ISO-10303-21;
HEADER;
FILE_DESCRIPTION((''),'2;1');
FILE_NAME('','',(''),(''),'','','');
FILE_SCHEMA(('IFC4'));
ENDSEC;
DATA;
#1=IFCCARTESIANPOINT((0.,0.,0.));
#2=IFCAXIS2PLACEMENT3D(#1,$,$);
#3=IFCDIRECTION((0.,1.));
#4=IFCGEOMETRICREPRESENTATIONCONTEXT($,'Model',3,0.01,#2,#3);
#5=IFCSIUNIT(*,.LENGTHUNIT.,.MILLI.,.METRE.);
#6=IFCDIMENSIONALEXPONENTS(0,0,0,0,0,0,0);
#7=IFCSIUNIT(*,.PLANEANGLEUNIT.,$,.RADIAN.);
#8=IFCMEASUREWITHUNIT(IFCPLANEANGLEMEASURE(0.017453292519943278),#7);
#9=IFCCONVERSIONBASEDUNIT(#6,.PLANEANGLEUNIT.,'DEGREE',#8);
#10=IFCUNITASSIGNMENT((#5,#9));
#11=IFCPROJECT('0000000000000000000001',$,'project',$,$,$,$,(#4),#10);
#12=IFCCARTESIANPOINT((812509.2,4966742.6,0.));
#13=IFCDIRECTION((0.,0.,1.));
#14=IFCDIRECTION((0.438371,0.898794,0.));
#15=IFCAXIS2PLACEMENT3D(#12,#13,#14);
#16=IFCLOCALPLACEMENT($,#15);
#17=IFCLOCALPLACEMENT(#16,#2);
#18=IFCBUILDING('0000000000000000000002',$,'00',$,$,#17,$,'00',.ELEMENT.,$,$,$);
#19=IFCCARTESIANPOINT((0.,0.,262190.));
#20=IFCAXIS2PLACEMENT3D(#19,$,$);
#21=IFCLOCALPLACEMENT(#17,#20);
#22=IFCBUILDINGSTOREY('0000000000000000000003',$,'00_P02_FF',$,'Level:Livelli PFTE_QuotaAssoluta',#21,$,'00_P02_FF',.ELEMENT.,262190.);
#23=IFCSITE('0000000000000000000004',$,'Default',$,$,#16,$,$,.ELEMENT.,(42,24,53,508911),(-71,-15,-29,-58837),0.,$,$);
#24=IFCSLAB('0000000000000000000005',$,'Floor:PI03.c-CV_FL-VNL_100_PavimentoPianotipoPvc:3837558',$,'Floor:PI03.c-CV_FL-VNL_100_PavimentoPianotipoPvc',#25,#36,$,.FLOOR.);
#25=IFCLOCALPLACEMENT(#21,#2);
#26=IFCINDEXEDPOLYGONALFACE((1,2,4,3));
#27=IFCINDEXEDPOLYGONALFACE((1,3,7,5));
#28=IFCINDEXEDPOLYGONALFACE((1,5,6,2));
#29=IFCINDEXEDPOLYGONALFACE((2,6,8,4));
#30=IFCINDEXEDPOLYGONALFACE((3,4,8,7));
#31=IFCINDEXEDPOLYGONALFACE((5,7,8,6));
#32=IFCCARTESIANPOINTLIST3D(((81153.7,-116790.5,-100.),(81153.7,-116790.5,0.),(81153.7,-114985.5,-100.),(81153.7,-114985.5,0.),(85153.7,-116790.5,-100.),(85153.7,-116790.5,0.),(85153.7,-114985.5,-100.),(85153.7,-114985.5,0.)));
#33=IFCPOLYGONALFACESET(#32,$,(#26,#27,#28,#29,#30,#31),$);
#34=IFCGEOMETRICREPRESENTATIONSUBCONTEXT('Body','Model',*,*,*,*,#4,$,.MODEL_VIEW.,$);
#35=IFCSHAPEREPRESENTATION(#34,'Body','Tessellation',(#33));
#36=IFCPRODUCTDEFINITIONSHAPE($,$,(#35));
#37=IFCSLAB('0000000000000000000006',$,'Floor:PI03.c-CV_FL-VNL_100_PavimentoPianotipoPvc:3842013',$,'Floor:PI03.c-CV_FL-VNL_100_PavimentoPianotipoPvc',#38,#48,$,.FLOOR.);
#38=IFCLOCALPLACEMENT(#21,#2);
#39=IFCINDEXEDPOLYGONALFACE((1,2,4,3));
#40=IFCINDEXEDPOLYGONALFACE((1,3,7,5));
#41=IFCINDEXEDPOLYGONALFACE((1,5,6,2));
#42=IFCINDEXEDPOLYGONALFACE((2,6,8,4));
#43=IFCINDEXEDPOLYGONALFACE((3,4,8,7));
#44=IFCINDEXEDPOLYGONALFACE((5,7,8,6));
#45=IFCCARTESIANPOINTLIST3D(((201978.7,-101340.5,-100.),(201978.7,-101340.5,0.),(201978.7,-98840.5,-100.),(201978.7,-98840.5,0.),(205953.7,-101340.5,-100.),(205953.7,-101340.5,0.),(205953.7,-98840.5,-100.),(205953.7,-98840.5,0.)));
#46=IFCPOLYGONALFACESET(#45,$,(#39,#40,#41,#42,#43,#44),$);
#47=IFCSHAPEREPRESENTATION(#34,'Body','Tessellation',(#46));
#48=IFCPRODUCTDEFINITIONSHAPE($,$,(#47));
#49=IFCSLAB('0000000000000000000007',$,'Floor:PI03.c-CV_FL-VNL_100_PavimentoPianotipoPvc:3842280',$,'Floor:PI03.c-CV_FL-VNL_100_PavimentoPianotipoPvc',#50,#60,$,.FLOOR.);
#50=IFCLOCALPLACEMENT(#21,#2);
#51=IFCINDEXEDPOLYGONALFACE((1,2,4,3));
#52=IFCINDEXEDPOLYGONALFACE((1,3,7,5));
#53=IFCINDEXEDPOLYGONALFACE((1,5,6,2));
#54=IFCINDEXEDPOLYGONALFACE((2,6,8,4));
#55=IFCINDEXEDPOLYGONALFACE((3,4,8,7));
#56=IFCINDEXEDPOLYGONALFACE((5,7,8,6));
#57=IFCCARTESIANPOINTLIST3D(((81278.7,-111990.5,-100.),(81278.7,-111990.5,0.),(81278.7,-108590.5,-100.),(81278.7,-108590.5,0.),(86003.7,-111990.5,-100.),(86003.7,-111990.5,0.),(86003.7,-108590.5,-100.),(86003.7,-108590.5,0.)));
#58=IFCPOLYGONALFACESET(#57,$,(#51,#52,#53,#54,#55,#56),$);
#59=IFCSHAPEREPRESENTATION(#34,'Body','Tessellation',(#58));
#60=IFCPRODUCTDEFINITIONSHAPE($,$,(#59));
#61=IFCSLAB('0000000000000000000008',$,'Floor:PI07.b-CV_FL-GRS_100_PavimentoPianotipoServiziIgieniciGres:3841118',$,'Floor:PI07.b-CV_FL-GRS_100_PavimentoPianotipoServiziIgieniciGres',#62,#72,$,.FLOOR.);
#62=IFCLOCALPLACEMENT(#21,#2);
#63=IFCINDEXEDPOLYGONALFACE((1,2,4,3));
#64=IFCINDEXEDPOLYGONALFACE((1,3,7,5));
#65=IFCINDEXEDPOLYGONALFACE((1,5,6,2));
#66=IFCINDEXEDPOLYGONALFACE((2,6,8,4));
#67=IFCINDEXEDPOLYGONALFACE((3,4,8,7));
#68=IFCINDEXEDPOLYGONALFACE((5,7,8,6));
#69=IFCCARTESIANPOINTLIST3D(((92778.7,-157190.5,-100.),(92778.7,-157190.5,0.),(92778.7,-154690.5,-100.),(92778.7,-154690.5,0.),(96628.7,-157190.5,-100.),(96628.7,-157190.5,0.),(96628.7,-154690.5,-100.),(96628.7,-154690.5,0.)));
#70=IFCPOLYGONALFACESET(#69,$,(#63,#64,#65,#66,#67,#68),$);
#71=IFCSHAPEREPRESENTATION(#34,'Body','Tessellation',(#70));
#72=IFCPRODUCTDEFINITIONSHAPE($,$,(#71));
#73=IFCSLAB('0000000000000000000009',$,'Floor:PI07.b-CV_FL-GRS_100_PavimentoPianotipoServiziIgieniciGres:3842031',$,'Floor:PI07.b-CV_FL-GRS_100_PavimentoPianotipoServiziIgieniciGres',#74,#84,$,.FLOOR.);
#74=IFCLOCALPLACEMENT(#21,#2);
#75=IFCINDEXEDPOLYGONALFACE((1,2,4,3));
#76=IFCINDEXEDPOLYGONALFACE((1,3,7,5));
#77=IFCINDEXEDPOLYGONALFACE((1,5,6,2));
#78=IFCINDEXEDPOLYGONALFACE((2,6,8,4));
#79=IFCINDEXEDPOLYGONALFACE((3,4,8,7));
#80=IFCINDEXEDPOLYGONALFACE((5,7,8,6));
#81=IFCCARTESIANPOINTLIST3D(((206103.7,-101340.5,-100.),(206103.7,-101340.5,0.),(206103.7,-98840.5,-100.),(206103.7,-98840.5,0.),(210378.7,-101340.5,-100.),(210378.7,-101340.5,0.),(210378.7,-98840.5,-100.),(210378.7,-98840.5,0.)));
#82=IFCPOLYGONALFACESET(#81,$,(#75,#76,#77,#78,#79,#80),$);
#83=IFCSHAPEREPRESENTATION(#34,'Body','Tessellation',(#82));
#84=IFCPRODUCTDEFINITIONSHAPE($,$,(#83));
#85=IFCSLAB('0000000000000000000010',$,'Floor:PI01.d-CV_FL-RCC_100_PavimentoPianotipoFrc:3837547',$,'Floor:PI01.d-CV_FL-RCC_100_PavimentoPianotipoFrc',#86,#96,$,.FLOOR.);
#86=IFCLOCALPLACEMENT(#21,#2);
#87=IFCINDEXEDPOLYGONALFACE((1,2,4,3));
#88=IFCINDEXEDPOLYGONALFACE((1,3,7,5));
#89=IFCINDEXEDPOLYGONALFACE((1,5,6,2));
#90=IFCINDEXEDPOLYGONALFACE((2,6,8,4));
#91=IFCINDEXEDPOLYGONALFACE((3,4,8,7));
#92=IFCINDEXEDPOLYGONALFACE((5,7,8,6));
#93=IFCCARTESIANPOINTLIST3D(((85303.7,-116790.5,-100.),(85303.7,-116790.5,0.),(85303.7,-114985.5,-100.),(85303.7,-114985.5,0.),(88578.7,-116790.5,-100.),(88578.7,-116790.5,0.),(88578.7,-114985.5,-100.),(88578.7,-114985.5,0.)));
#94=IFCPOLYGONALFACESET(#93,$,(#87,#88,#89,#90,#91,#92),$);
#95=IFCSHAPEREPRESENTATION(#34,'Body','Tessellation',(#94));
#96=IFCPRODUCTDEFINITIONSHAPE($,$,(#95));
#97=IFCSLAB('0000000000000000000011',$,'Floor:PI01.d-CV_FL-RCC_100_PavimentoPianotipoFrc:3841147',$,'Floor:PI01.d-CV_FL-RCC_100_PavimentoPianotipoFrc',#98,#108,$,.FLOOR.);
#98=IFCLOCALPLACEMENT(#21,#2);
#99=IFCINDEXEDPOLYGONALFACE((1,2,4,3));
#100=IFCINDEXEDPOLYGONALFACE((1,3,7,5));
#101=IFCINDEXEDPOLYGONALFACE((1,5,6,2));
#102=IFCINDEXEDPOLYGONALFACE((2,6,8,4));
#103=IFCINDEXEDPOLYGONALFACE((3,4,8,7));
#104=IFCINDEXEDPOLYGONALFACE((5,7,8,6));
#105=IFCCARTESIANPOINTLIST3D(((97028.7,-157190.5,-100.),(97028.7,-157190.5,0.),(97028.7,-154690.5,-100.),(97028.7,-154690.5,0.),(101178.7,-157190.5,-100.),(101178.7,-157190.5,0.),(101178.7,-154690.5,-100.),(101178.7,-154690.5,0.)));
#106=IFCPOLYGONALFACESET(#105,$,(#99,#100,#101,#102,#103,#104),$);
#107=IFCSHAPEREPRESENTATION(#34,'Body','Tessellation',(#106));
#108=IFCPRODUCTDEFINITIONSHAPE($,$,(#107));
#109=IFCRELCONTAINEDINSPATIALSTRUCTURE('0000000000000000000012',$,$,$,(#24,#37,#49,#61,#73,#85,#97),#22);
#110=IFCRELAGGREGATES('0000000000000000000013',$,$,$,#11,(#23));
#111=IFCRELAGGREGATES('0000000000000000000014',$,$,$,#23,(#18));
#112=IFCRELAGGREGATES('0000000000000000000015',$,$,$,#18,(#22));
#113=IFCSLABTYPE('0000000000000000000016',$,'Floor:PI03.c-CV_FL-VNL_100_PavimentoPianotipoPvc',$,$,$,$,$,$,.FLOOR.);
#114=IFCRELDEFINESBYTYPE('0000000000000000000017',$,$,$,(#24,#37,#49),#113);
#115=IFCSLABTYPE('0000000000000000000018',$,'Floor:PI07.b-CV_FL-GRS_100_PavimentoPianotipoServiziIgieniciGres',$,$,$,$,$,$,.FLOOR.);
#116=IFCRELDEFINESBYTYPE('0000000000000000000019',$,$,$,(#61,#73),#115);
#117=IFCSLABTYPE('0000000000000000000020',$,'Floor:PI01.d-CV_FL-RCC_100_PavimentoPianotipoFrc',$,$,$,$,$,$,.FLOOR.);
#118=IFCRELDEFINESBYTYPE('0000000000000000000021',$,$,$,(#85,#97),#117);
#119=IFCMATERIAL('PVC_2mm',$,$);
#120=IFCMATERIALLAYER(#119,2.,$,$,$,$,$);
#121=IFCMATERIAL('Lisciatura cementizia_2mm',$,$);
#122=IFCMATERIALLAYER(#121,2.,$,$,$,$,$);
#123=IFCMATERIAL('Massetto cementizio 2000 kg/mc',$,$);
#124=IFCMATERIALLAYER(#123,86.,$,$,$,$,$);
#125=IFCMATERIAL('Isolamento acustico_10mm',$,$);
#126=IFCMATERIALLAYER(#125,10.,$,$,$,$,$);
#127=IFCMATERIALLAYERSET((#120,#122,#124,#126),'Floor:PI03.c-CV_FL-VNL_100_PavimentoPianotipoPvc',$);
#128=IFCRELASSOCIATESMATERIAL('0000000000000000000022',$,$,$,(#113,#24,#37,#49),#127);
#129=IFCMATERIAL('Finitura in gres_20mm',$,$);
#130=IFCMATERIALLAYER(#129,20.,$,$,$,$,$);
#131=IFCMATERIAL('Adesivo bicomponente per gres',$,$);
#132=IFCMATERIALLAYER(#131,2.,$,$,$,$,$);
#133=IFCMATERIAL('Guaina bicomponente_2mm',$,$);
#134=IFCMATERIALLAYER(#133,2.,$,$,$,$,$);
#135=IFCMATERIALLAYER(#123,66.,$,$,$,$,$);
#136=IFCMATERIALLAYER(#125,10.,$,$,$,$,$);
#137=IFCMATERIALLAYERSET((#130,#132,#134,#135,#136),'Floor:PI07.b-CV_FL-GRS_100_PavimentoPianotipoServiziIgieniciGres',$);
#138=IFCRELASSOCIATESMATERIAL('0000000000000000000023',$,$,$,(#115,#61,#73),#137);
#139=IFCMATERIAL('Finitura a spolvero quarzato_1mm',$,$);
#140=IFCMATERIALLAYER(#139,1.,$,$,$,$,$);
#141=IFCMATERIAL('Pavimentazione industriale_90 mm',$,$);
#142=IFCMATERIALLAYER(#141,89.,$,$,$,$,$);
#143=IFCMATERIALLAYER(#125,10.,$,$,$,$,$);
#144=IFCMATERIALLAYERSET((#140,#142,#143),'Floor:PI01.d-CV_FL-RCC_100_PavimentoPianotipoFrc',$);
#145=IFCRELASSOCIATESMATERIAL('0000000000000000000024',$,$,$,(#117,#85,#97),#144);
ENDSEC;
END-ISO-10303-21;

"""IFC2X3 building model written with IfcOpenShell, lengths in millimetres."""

from ifc_helpers import new_model, entity, si_unit, converted_unit, direction, frame, frame_2d, origin, origin_2d_with_axis, place, context, subcontext, project, spatial, rectangle, extrude, material, layer, layer_set, layer_usage, type_object, element, save


model = new_model("IFC2X3")

# Units and contexts
model_context = context("Model", 3, precision=0.01, world=origin(), true_north=direction((0.0, 1.0)))
body_context = subcontext(model_context, "Body", "Model", "MODEL_VIEW")
ifc_project = project(units=[si_unit("LENGTHUNIT", "METRE", prefix="MILLI"), converted_unit("PLANEANGLEUNIT", "DEGREE", entity("IfcPlaneAngleMeasure", 0.017453292519943278), si_unit("PLANEANGLEUNIT", "RADIAN"), dimensions=[0, 0, 0, 0, 0, 0, 0])], contexts=[model_context])

# Site, building, storey
site_placement = place(None, frame((812509.2, 4966742.6, 0.0), z_axis=(0.0, 0.0, 1.0), x_axis=(0.438371, 0.898794, 0.0)))
site = spatial("IfcSite", under=ifc_project, at=site_placement, Name="Default", CompositionType="ELEMENT", RefLatitude=(42, 24, 53, 508911), RefLongitude=(-71, -15, -29, -58837), RefElevation=0.0)
building_placement = place(site_placement, origin())
building = spatial("IfcBuilding", under=site, at=building_placement, Name="00", LongName="00", CompositionType="ELEMENT")
storey_placement = place(building_placement, frame((0.0, 0.0, 262190.0)))
storey = spatial("IfcBuildingStorey", under=building, at=storey_placement, Name="00_P02_FF", ObjectType="Level:Livelli PFTE_QuotaAssoluta", LongName="00_P02_FF", CompositionType="ELEMENT", Elevation=262190.0)

# Slab
ifc_material_1 = material(Name="Finitura in gres_20mm")
ifc_material_2 = material(Name="Adesivo bicomponente per gres")
ifc_material_3 = material(Name="Massetto cementizio 2000 kg/mc")
ifc_material_4 = material(Name="Isolamento acustico_10mm")
ifc_material_5 = material(Name="PVC_2mm")
ifc_layer_1 = layer(ifc_material_5, 2.0)
ifc_material_6 = material(Name="Lisciatura cementizia_2mm")
ifc_layer_2 = layer(ifc_material_6, 2.0)
ifc_layer_3 = layer(ifc_material_3, 86.0)
ifc_layer_4 = layer(ifc_material_4, 10.0)
ifc_layer_set_1 = layer_set([ifc_layer_1, ifc_layer_2, ifc_layer_3, ifc_layer_4], Name="Floor:PI03.c-CV_FL-VNL_100_PavimentoPianotipoPvc")
slab_type_1 = type_object("IfcSlabType", Name="Floor:PI03.c-CV_FL-VNL_100_PavimentoPianotipoPvc", PredefinedType="FLOOR", material=ifc_layer_set_1)
ifc_layer_usage_1 = layer_usage(ifc_layer_set_1, "AXIS3", "POSITIVE", 0.0)
slab_1_placement = place(storey_placement, origin())
element("IfcSlab", 1, at=slab_1_placement, inside=storey, type_object=slab_type_1, material=ifc_layer_usage_1, Name="Floor:PI03.c-CV_FL-VNL_100_PavimentoPianotipoPvc:3837558", ObjectType="Floor:PI03.c-CV_FL-VNL_100_PavimentoPianotipoPvc", PredefinedType="FLOOR", context=body_context, shape_type="SweptSolid", body=[
    extrude(rectangle(XDim=1805.0, YDim=4000.0, at=frame_2d((0.0, 0.0), x_axis=(1.0, 0.0))), frame((83153.7, -115888.0, 0.0), z_axis=(0.0, 0.0, -1.0), x_axis=(0.0, 1.0, 0.0)), (0.0, 0.0, 1.0), 100.0),
])

# Slabs
ifc_layer_usage_2 = layer_usage(ifc_layer_set_1, "AXIS3", "POSITIVE", 0.0)
slab_2_placement = place(storey_placement, origin())
element("IfcSlab", 2, at=slab_2_placement, inside=storey, type_object=slab_type_1, material=ifc_layer_usage_2, Name="Floor:PI03.c-CV_FL-VNL_100_PavimentoPianotipoPvc:3842013", ObjectType="Floor:PI03.c-CV_FL-VNL_100_PavimentoPianotipoPvc", PredefinedType="FLOOR", context=body_context, shape_type="SweptSolid", body=[
    extrude(rectangle(XDim=2500.0, YDim=3975.0, at=frame_2d((0.0, 0.0), x_axis=(1.0, 0.0))), frame((203966.2, -100090.5, 0.0), z_axis=(0.0, 0.0, -1.0), x_axis=(0.0, 1.0, 0.0)), (0.0, 0.0, 1.0), 100.0),
])
ifc_layer_usage_3 = layer_usage(ifc_layer_set_1, "AXIS3", "POSITIVE", 0.0)
slab_3_placement = place(storey_placement, origin())
element("IfcSlab", 3, at=slab_3_placement, inside=storey, type_object=slab_type_1, material=ifc_layer_usage_3, Name="Floor:PI03.c-CV_FL-VNL_100_PavimentoPianotipoPvc:3842280", ObjectType="Floor:PI03.c-CV_FL-VNL_100_PavimentoPianotipoPvc", PredefinedType="FLOOR", context=body_context, shape_type="SweptSolid", body=[
    extrude(rectangle(XDim=3400.0, YDim=4725.0, at=frame_2d((0.0, 0.0), x_axis=(1.0, 0.0))), frame((83641.2, -110290.5, 0.0), z_axis=(0.0, 0.0, -1.0), x_axis=(0.0, 1.0, 0.0)), (0.0, 0.0, 1.0), 100.0),
])
ifc_layer_5 = layer(ifc_material_1, 20.0)
ifc_layer_6 = layer(ifc_material_2, 2.0)
ifc_material_7 = material(Name="Guaina bicomponente_2mm")
ifc_layer_7 = layer(ifc_material_7, 2.0)
ifc_layer_8 = layer(ifc_material_3, 66.0)
ifc_layer_9 = layer(ifc_material_4, 10.0)
ifc_layer_set_2 = layer_set([ifc_layer_5, ifc_layer_6, ifc_layer_7, ifc_layer_8, ifc_layer_9], Name="Floor:PI07.b-CV_FL-GRS_100_PavimentoPianotipoServiziIgieniciGres")
ifc_layer_usage_4 = layer_usage(ifc_layer_set_2, "AXIS3", "POSITIVE", 0.0)
slab_type_2 = type_object("IfcSlabType", Name="Floor:PI07.b-CV_FL-GRS_100_PavimentoPianotipoServiziIgieniciGres", PredefinedType="FLOOR", material=ifc_layer_set_2)
slab_4_placement = place(storey_placement, origin())
element("IfcSlab", 4, at=slab_4_placement, inside=storey, type_object=slab_type_2, material=ifc_layer_usage_4, Name="Floor:PI07.b-CV_FL-GRS_100_PavimentoPianotipoServiziIgieniciGres:3841118", ObjectType="Floor:PI07.b-CV_FL-GRS_100_PavimentoPianotipoServiziIgieniciGres", PredefinedType="FLOOR", context=body_context, shape_type="SweptSolid", body=[
    extrude(rectangle(XDim=2500.0, YDim=3850.0, at=frame_2d((0.0, 0.0), x_axis=(1.0, 0.0))), frame((94703.7, -155940.5, 0.0), z_axis=(0.0, 0.0, -1.0), x_axis=(0.0, 1.0, 0.0)), (0.0, 0.0, 1.0), 100.0),
])
ifc_layer_usage_5 = layer_usage(ifc_layer_set_2, "AXIS3", "POSITIVE", 0.0)
slab_5_placement = place(storey_placement, origin())
element("IfcSlab", 5, at=slab_5_placement, inside=storey, type_object=slab_type_2, material=ifc_layer_usage_5, Name="Floor:PI07.b-CV_FL-GRS_100_PavimentoPianotipoServiziIgieniciGres:3842031", ObjectType="Floor:PI07.b-CV_FL-GRS_100_PavimentoPianotipoServiziIgieniciGres", PredefinedType="FLOOR", context=body_context, shape_type="SweptSolid", body=[
    extrude(rectangle(XDim=2500.0, YDim=4275.0, at=origin_2d_with_axis()), frame((208241.2, -100090.5, 0.0), z_axis=(0.0, 0.0, -1.0), x_axis=(0.0, 1.0, 0.0)), (0.0, 0.0, 1.0), 100.0),
])
ifc_material_8 = material(Name="Finitura a spolvero quarzato_1mm")
ifc_layer_10 = layer(ifc_material_8, 1.0)
ifc_material_9 = material(Name="Pavimentazione industriale_90 mm")
ifc_layer_11 = layer(ifc_material_9, 89.0)
ifc_layer_12 = layer(ifc_material_4, 10.0)
ifc_layer_set_3 = layer_set([ifc_layer_10, ifc_layer_11, ifc_layer_12], Name="Floor:PI01.d-CV_FL-RCC_100_PavimentoPianotipoFrc")
slab_type_3 = type_object("IfcSlabType", Name="Floor:PI01.d-CV_FL-RCC_100_PavimentoPianotipoFrc", PredefinedType="FLOOR", material=ifc_layer_set_3)
ifc_layer_usage_6 = layer_usage(ifc_layer_set_3, "AXIS3", "POSITIVE", 0.0)
slab_6_placement = place(storey_placement, origin())
element("IfcSlab", 6, at=slab_6_placement, inside=storey, type_object=slab_type_3, material=ifc_layer_usage_6, Name="Floor:PI01.d-CV_FL-RCC_100_PavimentoPianotipoFrc:3837547", ObjectType="Floor:PI01.d-CV_FL-RCC_100_PavimentoPianotipoFrc", PredefinedType="FLOOR", context=body_context, shape_type="SweptSolid", body=[
    extrude(rectangle(XDim=1805.0, YDim=3275.0, at=frame_2d((0.0, 0.0), x_axis=(1.0, 0.0))), frame((86941.2, -115888.0, 0.0), z_axis=(0.0, 0.0, -1.0), x_axis=(0.0, 1.0, 0.0)), (0.0, 0.0, 1.0), 100.0),
])
ifc_layer_usage_7 = layer_usage(ifc_layer_set_3, "AXIS3", "POSITIVE", 0.0)
slab_7_placement = place(storey_placement, origin())
element("IfcSlab", 7, at=slab_7_placement, inside=storey, type_object=slab_type_3, material=ifc_layer_usage_7, Name="Floor:PI01.d-CV_FL-RCC_100_PavimentoPianotipoFrc:3841147", ObjectType="Floor:PI01.d-CV_FL-RCC_100_PavimentoPianotipoFrc", PredefinedType="FLOOR", context=body_context, shape_type="SweptSolid", body=[
    extrude(rectangle(XDim=2500.0, YDim=4150.0, at=origin_2d_with_axis()), frame((99103.7, -155940.5, 0.0), z_axis=(0.0, 0.0, -1.0), x_axis=(0.0, 1.0, 0.0)), (0.0, 0.0, 1.0), 100.0),
])

save(model, "model.ifc")
